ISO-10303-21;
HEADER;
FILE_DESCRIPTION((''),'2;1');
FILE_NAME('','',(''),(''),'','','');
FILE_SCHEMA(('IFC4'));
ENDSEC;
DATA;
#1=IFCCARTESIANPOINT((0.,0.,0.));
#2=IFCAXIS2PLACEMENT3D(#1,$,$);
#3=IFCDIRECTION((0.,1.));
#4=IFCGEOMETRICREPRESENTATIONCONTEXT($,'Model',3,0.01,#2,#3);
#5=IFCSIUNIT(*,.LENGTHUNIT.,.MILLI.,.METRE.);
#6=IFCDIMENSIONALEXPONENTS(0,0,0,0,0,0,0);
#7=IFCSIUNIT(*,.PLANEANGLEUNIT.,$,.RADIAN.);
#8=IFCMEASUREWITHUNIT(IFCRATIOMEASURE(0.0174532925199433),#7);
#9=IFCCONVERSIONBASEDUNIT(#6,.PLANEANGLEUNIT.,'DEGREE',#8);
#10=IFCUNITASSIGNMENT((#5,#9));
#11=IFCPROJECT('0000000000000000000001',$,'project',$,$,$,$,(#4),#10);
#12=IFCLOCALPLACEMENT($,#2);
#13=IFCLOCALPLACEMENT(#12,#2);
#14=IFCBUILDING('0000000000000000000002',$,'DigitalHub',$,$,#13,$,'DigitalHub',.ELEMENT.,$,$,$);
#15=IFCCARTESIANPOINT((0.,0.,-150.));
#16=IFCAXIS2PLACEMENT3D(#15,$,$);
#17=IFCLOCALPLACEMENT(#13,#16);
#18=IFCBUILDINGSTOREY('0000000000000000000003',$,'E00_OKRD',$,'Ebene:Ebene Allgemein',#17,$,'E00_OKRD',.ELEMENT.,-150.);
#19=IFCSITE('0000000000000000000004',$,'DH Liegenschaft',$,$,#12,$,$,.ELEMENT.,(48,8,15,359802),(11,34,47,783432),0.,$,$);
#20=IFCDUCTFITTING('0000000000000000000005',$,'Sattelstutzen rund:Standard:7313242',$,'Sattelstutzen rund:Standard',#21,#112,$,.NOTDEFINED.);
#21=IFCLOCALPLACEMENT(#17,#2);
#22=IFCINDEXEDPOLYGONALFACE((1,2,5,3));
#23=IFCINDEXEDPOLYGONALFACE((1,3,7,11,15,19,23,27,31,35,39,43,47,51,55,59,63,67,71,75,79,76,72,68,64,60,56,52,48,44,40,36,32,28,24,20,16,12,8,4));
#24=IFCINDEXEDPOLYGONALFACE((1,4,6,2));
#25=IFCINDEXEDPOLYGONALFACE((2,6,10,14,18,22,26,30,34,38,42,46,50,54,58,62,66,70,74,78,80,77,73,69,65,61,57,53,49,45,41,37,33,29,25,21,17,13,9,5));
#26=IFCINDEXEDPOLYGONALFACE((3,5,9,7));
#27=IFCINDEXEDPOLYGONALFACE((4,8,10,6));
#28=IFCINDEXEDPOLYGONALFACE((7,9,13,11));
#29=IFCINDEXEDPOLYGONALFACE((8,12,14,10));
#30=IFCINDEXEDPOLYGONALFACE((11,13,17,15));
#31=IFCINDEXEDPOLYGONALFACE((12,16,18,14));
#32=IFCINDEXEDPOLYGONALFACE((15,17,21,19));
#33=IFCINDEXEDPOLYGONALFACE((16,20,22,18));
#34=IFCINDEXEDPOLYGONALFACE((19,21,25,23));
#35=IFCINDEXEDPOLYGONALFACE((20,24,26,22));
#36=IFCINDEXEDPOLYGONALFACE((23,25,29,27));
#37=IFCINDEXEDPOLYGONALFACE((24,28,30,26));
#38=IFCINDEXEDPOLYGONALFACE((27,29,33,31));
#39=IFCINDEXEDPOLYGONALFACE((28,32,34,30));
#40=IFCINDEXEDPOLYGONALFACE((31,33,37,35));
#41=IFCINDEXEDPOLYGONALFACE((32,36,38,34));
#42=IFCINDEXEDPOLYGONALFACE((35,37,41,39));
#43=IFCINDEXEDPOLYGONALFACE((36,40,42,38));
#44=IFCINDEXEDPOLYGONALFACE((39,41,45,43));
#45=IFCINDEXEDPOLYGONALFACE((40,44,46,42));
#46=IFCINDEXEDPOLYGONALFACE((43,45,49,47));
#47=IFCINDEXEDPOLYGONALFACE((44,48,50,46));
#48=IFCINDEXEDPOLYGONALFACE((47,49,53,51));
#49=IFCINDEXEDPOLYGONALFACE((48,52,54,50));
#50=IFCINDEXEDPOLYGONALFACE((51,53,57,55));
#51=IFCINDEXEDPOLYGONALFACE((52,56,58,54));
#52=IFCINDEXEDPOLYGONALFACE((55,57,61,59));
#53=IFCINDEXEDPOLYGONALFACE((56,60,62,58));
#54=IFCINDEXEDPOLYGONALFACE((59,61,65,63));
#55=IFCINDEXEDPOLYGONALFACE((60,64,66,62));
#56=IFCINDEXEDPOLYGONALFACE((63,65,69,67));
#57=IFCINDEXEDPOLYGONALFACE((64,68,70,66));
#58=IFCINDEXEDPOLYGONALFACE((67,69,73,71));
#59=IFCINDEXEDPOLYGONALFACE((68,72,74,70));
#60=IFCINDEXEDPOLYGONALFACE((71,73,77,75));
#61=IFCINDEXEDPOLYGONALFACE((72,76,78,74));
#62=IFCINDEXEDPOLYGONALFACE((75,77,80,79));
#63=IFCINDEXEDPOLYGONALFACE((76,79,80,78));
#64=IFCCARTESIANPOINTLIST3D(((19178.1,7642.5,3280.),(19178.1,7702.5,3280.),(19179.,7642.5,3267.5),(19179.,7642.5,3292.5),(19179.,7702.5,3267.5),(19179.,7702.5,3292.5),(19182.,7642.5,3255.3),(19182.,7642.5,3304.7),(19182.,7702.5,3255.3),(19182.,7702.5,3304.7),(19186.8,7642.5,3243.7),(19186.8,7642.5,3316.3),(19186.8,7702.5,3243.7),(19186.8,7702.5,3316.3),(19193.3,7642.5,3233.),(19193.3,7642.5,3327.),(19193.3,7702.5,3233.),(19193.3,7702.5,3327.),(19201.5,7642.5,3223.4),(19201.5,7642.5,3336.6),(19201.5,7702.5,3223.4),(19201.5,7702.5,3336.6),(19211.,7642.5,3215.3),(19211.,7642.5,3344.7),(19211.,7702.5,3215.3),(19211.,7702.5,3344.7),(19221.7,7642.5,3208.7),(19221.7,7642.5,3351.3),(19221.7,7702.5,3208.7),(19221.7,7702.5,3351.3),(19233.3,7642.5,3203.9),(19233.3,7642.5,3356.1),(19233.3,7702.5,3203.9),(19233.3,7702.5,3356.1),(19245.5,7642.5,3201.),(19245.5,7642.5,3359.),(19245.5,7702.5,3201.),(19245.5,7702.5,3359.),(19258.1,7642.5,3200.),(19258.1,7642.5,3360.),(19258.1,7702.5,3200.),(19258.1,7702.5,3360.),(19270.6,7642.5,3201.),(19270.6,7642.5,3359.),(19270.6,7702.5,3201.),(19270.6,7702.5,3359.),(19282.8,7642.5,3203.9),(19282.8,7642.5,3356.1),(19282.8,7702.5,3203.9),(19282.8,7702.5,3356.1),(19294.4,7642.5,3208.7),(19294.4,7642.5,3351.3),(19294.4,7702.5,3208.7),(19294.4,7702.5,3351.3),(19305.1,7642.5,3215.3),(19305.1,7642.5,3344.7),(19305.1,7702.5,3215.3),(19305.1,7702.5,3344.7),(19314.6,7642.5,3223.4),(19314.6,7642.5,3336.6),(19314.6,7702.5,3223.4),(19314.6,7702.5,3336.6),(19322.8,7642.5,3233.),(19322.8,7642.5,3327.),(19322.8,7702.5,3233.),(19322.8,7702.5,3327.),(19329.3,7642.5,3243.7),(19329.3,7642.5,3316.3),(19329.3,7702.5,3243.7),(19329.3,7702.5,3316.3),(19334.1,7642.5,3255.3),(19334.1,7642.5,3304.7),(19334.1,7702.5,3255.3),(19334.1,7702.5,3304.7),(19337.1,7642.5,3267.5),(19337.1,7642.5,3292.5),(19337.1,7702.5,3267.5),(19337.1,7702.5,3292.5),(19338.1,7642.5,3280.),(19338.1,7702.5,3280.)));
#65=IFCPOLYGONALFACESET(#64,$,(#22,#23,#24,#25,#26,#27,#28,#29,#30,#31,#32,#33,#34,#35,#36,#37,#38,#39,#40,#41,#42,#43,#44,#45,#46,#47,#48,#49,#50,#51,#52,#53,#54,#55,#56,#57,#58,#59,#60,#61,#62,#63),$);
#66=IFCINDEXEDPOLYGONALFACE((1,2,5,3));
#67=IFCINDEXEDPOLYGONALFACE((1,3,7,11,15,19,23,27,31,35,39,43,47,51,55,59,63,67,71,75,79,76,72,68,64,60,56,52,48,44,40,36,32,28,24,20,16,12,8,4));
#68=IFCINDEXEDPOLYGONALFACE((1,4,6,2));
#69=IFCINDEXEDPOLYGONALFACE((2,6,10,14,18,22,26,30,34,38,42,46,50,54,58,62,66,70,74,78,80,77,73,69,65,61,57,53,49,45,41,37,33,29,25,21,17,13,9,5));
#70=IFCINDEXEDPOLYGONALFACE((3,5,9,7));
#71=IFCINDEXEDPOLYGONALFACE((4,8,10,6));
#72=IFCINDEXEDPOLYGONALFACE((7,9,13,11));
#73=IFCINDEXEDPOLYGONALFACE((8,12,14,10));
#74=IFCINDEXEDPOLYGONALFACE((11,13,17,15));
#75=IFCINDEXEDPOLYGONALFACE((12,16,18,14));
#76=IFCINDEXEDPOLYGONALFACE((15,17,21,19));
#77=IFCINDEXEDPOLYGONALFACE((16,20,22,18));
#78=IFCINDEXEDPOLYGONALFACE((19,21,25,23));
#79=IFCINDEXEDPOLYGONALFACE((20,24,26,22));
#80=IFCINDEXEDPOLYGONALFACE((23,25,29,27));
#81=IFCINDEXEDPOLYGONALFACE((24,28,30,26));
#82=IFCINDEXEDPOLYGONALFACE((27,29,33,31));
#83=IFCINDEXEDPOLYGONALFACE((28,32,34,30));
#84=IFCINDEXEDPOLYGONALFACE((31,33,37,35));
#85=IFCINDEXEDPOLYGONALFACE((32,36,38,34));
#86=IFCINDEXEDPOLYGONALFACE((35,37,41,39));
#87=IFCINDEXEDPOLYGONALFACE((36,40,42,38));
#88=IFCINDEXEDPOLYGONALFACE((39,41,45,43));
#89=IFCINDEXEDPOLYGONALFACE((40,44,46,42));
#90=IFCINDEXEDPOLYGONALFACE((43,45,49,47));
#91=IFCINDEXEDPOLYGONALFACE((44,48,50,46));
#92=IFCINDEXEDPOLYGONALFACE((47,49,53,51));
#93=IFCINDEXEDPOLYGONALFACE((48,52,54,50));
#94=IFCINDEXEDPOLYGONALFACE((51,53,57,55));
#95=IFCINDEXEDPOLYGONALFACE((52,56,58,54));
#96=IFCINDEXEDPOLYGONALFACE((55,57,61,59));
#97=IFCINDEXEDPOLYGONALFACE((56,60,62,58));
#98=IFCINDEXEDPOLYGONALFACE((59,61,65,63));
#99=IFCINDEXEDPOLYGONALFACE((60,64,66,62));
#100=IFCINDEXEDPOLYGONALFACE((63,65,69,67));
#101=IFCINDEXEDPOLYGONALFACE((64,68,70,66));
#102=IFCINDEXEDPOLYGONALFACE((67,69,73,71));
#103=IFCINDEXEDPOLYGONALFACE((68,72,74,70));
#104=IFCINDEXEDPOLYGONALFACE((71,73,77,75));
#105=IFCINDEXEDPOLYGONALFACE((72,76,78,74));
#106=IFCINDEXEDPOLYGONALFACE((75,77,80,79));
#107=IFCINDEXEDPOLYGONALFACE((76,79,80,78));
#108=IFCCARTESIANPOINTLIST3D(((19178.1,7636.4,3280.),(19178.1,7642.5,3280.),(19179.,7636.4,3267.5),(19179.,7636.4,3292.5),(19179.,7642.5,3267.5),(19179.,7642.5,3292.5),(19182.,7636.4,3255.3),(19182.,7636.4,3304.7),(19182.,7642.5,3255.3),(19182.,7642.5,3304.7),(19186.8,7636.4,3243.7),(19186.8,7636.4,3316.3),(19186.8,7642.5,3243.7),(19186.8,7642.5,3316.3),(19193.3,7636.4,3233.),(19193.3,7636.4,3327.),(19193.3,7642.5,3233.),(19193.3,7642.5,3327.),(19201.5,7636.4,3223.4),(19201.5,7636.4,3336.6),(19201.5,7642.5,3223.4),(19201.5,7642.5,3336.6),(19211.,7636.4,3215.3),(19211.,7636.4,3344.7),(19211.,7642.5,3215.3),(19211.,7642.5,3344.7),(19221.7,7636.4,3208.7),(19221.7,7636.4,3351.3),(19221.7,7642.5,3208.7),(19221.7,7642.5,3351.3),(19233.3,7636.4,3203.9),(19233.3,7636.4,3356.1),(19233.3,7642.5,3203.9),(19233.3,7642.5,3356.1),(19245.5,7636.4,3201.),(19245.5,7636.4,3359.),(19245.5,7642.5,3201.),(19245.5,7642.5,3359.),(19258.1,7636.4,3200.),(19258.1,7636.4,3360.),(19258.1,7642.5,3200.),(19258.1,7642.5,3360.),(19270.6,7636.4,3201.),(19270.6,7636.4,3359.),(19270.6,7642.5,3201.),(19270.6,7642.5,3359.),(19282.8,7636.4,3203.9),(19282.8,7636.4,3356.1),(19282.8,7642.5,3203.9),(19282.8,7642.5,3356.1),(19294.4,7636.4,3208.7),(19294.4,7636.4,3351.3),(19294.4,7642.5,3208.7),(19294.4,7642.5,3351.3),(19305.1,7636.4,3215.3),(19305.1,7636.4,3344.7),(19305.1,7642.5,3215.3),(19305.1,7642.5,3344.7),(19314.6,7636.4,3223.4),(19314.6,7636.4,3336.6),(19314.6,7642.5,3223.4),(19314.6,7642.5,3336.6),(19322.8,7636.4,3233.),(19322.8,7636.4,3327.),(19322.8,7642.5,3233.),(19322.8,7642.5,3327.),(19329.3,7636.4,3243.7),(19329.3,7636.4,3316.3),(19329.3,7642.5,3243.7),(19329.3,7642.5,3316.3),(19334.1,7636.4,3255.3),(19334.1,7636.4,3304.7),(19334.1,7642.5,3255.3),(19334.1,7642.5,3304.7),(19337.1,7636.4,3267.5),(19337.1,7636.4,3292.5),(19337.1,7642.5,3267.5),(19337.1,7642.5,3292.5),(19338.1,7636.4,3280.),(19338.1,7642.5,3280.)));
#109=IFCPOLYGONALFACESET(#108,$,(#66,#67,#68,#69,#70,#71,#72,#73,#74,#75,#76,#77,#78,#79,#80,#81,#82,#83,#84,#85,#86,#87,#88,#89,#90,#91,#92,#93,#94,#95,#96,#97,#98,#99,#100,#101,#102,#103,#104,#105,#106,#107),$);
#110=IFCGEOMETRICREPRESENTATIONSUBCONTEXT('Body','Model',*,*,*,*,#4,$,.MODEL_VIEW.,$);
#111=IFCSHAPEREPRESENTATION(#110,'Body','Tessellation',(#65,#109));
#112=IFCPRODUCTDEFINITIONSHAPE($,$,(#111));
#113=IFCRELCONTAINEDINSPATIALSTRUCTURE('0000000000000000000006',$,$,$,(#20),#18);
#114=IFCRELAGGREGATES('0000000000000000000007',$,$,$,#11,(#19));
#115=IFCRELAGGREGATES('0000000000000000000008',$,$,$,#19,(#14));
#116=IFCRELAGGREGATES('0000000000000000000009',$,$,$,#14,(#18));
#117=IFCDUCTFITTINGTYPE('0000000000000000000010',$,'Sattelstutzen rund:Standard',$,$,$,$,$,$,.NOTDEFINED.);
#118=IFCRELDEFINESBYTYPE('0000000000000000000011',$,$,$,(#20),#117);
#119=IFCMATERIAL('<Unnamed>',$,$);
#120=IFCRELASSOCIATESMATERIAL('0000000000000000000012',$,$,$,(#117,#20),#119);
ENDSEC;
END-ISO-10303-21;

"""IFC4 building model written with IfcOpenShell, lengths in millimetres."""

from ifc_helpers import new_model, entity, si_unit, converted_unit, direction, frame, origin, place, context, subcontext, project, spatial, indexed_curve, outline, extrude, source, transform, mapped, material, type_object, type_shapes, element, save


model = new_model("IFC4")

# Units and contexts
model_context = context("Model", 3, precision=0.01, world=origin(), true_north=direction((0.0, 1.0)))
body_context = subcontext(model_context, "Body", "Model", "MODEL_VIEW")
ifc_project = project(units=[si_unit("LENGTHUNIT", "METRE", prefix="MILLI"), converted_unit("PLANEANGLEUNIT", "DEGREE", entity("IfcRatioMeasure", 0.0174532925199433), si_unit("PLANEANGLEUNIT", "RADIAN"), dimensions=[0, 0, 0, 0, 0, 0, 0])], contexts=[model_context])

# Site, building, storey
site_placement = place(None, origin())
site = spatial("IfcSite", under=ifc_project, at=site_placement, Name="DH Liegenschaft", CompositionType="ELEMENT", RefLatitude=(48, 8, 15, 359802), RefLongitude=(11, 34, 47, 783432), RefElevation=0.0)
building_placement = place(site_placement, origin())
building = spatial("IfcBuilding", under=site, at=building_placement, Name="DigitalHub", LongName="DigitalHub", CompositionType="ELEMENT")
storey_placement = place(building_placement, frame((0.0, 0.0, -150.0)))
storey = spatial("IfcBuildingStorey", under=building, at=storey_placement, Name="E00_OKRD", ObjectType="Ebene:Ebene Allgemein", LongName="E00_OKRD", CompositionType="ELEMENT", Elevation=-150.0)

# Shared definitions
ifc_material_1 = material(Name="<Unnamed>")

# Duct fitting
duct_fitting_type_1 = type_object("IfcDuctFittingType", Name="Sattelstutzen rund:Standard", PredefinedType="NOTDEFINED", material=ifc_material_1)
shared_shape_1 = source(origin(), body_context, "Body", "SweptSolid", [
    extrude(outline(indexed_curve([(0.0, 80.0), (-12.5, 79.0), (-24.7, 76.1), (-36.3, 71.3), (-47.0, 64.7), (-56.6, 56.6), (-64.7, 47.0), (-71.3, 36.3), (-76.1, 24.7), (-79.0, 12.5), (-80.0, 0.0), (-79.0, -12.5), (-76.1, -24.7), (-71.3, -36.3), (-64.7, -47.0), (-56.6, -56.6), (-47.0, -64.7), (-36.3, -71.3), (-24.7, -76.1), (-12.5, -79.0), (0.0, -80.0), (12.5, -79.0), (24.7, -76.1), (36.3, -71.3), (47.0, -64.7), (56.6, -56.6), (64.7, -47.0), (71.3, -36.3), (76.1, -24.7), (79.0, -12.5), (80.0, 0.0), (79.0, 12.5), (76.1, 24.7), (71.3, 36.3), (64.7, 47.0), (56.6, 56.6), (47.0, 64.7), (36.3, 71.3), (24.7, 76.1), (12.5, 79.0), (0.0, 80.0)], self_intersect=False)), frame((0.0, 0.0, 0.0), z_axis=(1.0, 0.0, 0.0), x_axis=(0.0, 1.0, 0.0)), (0.0, 0.0, 1.0), 60.0),
    extrude(outline(indexed_curve([(0.0, 80.0), (-12.5, 79.0), (-24.7, 76.1), (-36.3, 71.3), (-47.0, 64.7), (-56.6, 56.6), (-64.7, 47.0), (-71.3, 36.3), (-76.1, 24.7), (-79.0, 12.5), (-80.0, 0.0), (-79.0, -12.5), (-76.1, -24.7), (-71.3, -36.3), (-64.7, -47.0), (-56.6, -56.6), (-47.0, -64.7), (-36.3, -71.3), (-24.7, -76.1), (-12.5, -79.0), (0.0, -80.0), (12.5, -79.0), (24.7, -76.1), (36.3, -71.3), (47.0, -64.7), (56.6, -56.6), (64.7, -47.0), (71.3, -36.3), (76.1, -24.7), (79.0, -12.5), (80.0, 0.0), (79.0, 12.5), (76.1, 24.7), (71.3, 36.3), (64.7, 47.0), (56.6, 56.6), (47.0, 64.7), (36.3, 71.3), (24.7, 76.1), (12.5, 79.0), (0.0, 80.0)], self_intersect=False)), frame((-6.1, 0.0, 0.0), z_axis=(1.0, 0.0, 0.0), x_axis=(0.0, 1.0, 0.0)), (0.0, 0.0, 1.0), 6.1),
])
type_shapes(duct_fitting_type_1, [shared_shape_1])
for number, where, z_axis, x_axis, name in (
    (1, (19258.1, 7642.5, 3280.0), (0.0, 0.0, -1.0), (0.0, 1.0, 0.0), "Sattelstutzen rund:Standard:7313242"),
):
    element("IfcDuctFitting", number, at=place(storey_placement, frame(where, z_axis=z_axis, x_axis=x_axis)), inside=storey, type_object=duct_fitting_type_1, material=ifc_material_1, Name=name, ObjectType="Sattelstutzen rund:Standard", PredefinedType="NOTDEFINED", context=body_context, shape_type="MappedRepresentation", body=[
        mapped(shared_shape_1, transform((0.0, 0.0, 0.0), scale=1.0)),
    ])

save(model, "model.ifc")
